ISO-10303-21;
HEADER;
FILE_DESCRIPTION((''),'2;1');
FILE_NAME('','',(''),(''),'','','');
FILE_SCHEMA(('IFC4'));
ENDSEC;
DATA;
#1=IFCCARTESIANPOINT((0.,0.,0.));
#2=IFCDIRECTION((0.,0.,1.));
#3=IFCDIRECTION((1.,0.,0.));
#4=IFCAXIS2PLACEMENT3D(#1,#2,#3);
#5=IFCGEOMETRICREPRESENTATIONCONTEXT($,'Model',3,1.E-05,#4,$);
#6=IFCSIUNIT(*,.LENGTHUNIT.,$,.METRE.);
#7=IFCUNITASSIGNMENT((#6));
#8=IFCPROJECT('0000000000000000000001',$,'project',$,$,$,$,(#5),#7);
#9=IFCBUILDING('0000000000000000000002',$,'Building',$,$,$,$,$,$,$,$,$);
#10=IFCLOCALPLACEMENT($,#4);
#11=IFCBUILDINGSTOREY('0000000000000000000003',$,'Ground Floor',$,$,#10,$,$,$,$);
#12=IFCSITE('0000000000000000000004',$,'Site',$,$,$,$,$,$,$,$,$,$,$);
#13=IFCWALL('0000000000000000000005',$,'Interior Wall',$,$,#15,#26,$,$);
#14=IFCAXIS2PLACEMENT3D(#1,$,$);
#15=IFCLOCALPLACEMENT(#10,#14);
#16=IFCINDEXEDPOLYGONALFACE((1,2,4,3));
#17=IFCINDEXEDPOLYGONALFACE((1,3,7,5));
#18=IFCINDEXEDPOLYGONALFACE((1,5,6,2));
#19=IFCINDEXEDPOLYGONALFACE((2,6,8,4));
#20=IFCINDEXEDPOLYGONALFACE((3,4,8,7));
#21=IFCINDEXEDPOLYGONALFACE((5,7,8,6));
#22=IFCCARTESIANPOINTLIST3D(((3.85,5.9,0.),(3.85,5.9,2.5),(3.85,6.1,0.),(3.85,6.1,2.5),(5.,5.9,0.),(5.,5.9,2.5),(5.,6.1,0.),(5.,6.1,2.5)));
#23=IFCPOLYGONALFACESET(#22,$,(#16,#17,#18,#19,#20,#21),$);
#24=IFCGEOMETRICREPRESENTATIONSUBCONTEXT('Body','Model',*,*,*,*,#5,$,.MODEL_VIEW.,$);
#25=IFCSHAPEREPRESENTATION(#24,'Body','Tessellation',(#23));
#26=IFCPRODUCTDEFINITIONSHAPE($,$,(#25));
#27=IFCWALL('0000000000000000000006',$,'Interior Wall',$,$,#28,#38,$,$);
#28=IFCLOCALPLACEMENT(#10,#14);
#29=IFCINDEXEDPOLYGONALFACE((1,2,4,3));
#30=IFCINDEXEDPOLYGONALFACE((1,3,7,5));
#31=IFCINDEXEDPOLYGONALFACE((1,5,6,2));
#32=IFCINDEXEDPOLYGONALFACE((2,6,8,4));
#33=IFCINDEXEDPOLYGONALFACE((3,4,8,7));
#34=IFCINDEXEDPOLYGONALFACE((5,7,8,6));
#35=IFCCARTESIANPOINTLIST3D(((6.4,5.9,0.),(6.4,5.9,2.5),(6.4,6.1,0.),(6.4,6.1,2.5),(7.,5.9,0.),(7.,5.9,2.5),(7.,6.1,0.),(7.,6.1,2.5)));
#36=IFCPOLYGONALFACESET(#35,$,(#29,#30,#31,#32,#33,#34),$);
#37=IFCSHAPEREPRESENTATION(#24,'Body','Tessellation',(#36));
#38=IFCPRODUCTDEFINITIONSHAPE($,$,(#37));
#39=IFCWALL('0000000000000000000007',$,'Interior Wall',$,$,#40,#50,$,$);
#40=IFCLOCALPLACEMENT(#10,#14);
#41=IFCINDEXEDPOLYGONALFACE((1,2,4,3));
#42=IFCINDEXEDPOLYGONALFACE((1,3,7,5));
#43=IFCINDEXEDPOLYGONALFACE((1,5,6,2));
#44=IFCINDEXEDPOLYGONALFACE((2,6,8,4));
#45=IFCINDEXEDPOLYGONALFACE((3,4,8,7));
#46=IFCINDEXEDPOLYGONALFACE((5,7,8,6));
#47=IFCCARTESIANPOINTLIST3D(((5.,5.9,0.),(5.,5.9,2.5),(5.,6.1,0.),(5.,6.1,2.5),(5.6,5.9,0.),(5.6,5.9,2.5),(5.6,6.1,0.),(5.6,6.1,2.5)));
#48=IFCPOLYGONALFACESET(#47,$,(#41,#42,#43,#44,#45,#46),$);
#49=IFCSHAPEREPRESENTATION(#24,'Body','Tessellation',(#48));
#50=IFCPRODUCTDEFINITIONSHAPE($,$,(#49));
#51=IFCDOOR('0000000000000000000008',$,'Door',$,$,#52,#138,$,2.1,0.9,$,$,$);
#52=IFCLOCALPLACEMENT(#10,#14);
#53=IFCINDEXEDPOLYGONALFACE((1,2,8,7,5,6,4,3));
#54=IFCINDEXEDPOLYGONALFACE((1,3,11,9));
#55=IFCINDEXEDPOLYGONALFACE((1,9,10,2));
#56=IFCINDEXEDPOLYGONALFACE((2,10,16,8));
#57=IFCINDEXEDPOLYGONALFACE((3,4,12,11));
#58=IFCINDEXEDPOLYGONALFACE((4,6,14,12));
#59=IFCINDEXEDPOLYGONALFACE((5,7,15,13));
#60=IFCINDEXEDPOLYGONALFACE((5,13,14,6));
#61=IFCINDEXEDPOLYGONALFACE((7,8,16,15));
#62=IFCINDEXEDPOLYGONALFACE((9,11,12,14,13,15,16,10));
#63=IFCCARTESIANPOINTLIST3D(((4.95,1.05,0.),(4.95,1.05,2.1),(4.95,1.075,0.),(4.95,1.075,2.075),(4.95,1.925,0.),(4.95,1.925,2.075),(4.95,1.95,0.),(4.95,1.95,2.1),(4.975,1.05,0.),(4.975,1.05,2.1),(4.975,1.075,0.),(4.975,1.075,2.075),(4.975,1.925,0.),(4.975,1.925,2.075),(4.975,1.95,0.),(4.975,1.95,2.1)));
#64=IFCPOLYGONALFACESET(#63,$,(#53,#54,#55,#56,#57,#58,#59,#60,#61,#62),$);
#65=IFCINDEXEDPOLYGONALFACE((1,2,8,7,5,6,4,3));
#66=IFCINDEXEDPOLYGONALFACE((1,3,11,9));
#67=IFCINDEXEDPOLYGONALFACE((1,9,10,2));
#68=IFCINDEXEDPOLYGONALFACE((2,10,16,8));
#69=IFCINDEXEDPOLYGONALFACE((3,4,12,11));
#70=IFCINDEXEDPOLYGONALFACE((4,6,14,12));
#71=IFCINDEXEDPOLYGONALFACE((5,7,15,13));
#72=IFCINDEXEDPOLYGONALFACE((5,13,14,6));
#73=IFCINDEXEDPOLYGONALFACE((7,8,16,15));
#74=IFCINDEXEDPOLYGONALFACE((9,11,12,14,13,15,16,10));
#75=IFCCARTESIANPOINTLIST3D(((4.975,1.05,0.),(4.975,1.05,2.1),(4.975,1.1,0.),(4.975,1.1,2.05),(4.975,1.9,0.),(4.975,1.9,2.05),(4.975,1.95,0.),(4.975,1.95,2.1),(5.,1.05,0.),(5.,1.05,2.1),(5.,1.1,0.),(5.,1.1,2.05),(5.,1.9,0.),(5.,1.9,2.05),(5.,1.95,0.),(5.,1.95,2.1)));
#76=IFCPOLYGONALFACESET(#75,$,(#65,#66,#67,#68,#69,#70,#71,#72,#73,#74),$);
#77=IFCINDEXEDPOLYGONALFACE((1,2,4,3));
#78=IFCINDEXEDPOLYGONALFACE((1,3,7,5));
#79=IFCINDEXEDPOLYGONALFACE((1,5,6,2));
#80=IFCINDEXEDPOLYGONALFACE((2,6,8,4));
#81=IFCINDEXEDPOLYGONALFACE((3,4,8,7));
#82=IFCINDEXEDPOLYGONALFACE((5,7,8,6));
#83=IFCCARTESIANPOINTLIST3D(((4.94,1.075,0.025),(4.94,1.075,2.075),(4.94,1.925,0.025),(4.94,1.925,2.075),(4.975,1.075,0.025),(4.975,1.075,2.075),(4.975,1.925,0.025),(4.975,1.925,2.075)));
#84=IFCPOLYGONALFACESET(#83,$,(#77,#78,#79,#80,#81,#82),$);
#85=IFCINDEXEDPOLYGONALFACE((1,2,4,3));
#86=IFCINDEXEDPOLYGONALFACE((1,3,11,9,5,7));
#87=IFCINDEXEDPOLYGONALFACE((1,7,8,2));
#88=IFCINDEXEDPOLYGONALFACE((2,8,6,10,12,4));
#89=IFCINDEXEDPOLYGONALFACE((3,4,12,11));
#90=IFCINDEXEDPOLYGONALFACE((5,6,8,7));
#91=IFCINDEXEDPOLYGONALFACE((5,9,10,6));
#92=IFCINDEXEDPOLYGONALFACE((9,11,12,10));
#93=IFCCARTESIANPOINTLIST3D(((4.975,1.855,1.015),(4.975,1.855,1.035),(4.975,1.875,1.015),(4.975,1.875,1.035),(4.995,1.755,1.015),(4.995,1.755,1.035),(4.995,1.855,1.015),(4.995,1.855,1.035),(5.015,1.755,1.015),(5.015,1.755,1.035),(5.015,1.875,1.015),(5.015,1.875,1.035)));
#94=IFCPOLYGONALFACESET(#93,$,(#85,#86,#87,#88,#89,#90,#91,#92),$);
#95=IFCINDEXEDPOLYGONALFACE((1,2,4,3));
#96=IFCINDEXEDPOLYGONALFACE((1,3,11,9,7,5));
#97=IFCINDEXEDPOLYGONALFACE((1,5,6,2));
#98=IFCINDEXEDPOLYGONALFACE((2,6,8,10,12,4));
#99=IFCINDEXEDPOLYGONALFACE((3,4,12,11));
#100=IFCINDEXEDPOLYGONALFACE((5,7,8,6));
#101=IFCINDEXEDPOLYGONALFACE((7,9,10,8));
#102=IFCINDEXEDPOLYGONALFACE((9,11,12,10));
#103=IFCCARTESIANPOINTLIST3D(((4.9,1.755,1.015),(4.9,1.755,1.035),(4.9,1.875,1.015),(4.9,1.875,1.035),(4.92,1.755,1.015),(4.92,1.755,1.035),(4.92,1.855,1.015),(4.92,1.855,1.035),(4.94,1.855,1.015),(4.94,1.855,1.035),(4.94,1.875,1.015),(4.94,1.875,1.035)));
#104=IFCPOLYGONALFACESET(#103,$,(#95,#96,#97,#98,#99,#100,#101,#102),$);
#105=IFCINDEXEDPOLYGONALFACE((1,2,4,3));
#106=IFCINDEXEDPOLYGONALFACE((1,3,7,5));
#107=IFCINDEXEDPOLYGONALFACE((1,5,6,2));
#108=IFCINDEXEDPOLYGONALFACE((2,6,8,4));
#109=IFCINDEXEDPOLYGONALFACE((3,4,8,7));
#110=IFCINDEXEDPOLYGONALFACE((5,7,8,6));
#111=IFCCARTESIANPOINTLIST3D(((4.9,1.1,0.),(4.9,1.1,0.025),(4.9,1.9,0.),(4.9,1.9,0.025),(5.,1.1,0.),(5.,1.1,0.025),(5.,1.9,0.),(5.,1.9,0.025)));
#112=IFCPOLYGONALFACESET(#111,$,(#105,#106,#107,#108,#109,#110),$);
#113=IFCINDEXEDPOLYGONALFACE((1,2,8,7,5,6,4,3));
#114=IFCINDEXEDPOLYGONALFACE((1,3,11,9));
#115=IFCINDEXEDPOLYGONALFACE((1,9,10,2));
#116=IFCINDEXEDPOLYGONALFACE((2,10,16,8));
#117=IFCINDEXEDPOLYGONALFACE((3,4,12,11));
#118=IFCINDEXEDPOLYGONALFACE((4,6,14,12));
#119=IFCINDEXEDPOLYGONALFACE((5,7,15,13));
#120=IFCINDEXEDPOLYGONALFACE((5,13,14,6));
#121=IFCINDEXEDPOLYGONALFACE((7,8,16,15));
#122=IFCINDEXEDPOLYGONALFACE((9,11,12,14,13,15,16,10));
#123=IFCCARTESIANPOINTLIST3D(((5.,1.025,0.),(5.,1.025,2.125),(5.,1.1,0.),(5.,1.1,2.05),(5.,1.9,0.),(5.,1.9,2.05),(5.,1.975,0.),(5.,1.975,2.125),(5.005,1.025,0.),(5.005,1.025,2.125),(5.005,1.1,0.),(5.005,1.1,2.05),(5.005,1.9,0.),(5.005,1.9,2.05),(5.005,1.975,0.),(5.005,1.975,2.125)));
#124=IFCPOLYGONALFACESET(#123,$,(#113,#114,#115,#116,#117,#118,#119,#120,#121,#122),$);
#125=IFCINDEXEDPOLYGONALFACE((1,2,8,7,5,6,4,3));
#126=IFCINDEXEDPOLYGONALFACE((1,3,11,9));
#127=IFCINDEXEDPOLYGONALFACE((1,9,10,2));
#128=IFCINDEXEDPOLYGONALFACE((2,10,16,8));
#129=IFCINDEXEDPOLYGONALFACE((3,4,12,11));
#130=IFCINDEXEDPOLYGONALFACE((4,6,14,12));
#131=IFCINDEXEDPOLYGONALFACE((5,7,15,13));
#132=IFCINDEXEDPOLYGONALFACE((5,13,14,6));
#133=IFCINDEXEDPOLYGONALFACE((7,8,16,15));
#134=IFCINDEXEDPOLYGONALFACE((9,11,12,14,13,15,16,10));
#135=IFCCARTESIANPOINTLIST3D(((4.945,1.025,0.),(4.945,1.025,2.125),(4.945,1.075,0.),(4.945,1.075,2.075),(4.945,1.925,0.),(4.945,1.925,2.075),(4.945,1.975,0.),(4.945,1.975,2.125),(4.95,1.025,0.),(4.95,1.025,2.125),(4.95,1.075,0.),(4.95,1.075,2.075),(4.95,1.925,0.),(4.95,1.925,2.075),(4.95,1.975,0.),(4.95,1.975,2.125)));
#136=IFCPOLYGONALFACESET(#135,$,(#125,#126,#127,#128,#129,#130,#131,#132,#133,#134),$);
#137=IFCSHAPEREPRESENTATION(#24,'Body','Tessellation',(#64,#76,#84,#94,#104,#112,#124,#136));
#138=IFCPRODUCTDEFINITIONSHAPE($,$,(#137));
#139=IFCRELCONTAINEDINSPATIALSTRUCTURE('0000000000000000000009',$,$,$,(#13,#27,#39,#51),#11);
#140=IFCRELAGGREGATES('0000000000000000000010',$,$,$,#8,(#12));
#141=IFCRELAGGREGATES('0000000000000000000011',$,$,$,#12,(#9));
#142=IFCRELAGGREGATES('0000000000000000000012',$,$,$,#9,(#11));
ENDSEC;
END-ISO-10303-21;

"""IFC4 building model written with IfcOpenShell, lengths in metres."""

from ifc_helpers import new_model, si_unit, frame, origin_with_axes, place, context, subcontext, project, spatial, line, indexed_curve, outline, extrude, element, save


model = new_model("IFC4")

# Units and contexts
model_context = context("Model", 3, precision=1e-05, world=origin_with_axes())
body_context = subcontext(model_context, "Body", "Model", "MODEL_VIEW")
ifc_project = project(units=[si_unit("LENGTHUNIT", "METRE")], contexts=[model_context])

# Site, building, storey
site = spatial("IfcSite", under=ifc_project, Name="Site")
building = spatial("IfcBuilding", under=site, Name="Building")
storey_placement = place(None, origin_with_axes())
storey = spatial("IfcBuildingStorey", under=building, at=storey_placement, Name="Ground Floor")

# Walls
wall_1_placement = place(storey_placement, frame((5.0, 6.0, 0.0), z_axis=(0.0, 0.0, 1.0), x_axis=(-1.0, 0.0, 0.0)))
element("IfcWall", 1, at=wall_1_placement, inside=storey, Name="Interior Wall", context=body_context, shape_type="SweptSolid", body=[
    extrude(outline(indexed_curve([(0.0, 0.0), (0.0, 0.2), (1.15, 0.2), (1.15, 0.0), (0.0, 0.0)], self_intersect=False)), frame((0.0, -0.1, 0.0), z_axis=(0.0, 0.0, 1.0), x_axis=(1.0, 0.0, 0.0)), (0.0, 0.0, 1.0), 2.5),
])
for number, where, z_axis, x_axis, name in (
    (2, (7.0, 6.0, 0.0), (0.0, 0.0, 1.0), (-1.0, 0.0, 0.0), "Interior Wall"),
    (3, (5.6, 6.0, 0.0), (0.0, 0.0, 1.0), (-1.0, 0.0, 0.0), "Interior Wall"),
):
    element("IfcWall", number, at=place(storey_placement, frame(where, z_axis=z_axis, x_axis=x_axis)), inside=storey, Name=name, context=body_context, shape_type="SweptSolid", body=[
        extrude(outline(indexed_curve([(0.0, 0.0), (0.0, 0.2), (0.6, 0.2), (0.6, 0.0), (0.0, 0.0)], self_intersect=False)), frame((0.0, -0.1, 0.0), z_axis=(0.0, 0.0, 1.0), x_axis=(1.0, 0.0, 0.0)), (0.0, 0.0, 1.0), 2.5),
    ])

# Door
door_1_placement = place(storey_placement, frame((5.0, 1.05, 0.0), z_axis=(0.0, 0.0, 1.0), x_axis=(0.0, 1.0, 0.0)))
element("IfcDoor", 4, at=door_1_placement, inside=storey, Name="Door", OverallHeight=2.1, OverallWidth=0.9, context=body_context, shape_type="SweptSolid", body=[
    extrude(outline(indexed_curve([(0.0, 0.0), (0.0, 2.1), (0.9, 2.1), (0.9, 0.0), (0.875, 0.0), (0.875, 2.075), (0.025, 2.075), (0.025, 0.0)], segments=[line(1, 2, 3, 4, 5, 6, 7, 8, 1)])), frame((0.0, 0.025, 0.0), z_axis=(0.0, -1.0, 0.0), x_axis=(1.0, 0.0, 0.0)), (0.0, 0.0, -1.0), 0.025),
    extrude(outline(indexed_curve([(0.0, 0.0), (0.0, 2.1), (0.9, 2.1), (0.9, 0.0), (0.85, 0.0), (0.85, 2.05), (0.05, 2.05), (0.05, 0.0)], segments=[line(1, 2, 3, 4, 5, 6, 7, 8, 1)])), frame((0.0, 0.0, 0.0), z_axis=(0.0, -1.0, 0.0), x_axis=(1.0, 0.0, 0.0)), (0.0, 0.0, -1.0), 0.025),
    extrude(outline(indexed_curve([(0.0, 0.0), (0.85, 0.0), (0.85, 0.035), (0.0, 0.035)], segments=[line(1, 2, 3, 4, 1)])), frame((0.025, 0.025, 0.025), z_axis=(0.0, 0.0, 1.0), x_axis=(1.0, 0.0, 0.0)), (0.0, 0.0, 1.0), 2.05),
    extrude(outline(indexed_curve([(0.0, 0.0), (0.0, -0.04), (-0.12, -0.04), (-0.12, -0.02), (-0.02, -0.02), (-0.02, 0.0)], segments=[line(1, 2, 3, 4, 5, 6, 1)])), frame((0.825, 0.025, 1.015), z_axis=(0.0, 0.0, 1.0), x_axis=(1.0, 0.0, 0.0)), (0.0, 0.0, 1.0), 0.02),
    extrude(outline(indexed_curve([(0.0, 0.0), (0.0, 0.04), (-0.12, 0.04), (-0.12, 0.02), (-0.02, 0.02), (-0.02, 0.0)], segments=[line(1, 2, 3, 4, 5, 6, 1)])), frame((0.825, 0.06, 1.015), z_axis=(0.0, 0.0, 1.0), x_axis=(1.0, 0.0, 0.0)), (0.0, 0.0, 1.0), 0.02),
    extrude(outline(indexed_curve([(0.0, 0.0), (0.8, 0.0), (0.8, 0.1), (0.0, 0.1)], segments=[line(1, 2, 3, 4, 1)])), frame((0.05, 0.0, 0.0), z_axis=(0.0, 0.0, 1.0), x_axis=(1.0, 0.0, 0.0)), (0.0, 0.0, 1.0), 0.025),
    extrude(outline(indexed_curve([(0.0, 0.0), (0.0, 2.125), (0.95, 2.125), (0.95, 0.0), (0.875, 0.0), (0.875, 2.05), (0.075, 2.05), (0.075, 0.0)], segments=[line(1, 2, 3, 4, 5, 6, 7, 8, 1)])), frame((-0.025, -0.005, 0.0), z_axis=(0.0, -1.0, 0.0), x_axis=(1.0, 0.0, 0.0)), (0.0, 0.0, -1.0), 0.005),
    extrude(outline(indexed_curve([(0.0, 0.0), (0.0, 2.125), (0.95, 2.125), (0.95, 0.0), (0.9, 0.0), (0.9, 2.075), (0.05, 2.075), (0.05, 0.0)], segments=[line(1, 2, 3, 4, 5, 6, 7, 8, 1)])), frame((-0.025, 0.05, 0.0), z_axis=(0.0, -1.0, 0.0), x_axis=(1.0, 0.0, 0.0)), (0.0, 0.0, -1.0), 0.005),
])

save(model, "model.ifc")
